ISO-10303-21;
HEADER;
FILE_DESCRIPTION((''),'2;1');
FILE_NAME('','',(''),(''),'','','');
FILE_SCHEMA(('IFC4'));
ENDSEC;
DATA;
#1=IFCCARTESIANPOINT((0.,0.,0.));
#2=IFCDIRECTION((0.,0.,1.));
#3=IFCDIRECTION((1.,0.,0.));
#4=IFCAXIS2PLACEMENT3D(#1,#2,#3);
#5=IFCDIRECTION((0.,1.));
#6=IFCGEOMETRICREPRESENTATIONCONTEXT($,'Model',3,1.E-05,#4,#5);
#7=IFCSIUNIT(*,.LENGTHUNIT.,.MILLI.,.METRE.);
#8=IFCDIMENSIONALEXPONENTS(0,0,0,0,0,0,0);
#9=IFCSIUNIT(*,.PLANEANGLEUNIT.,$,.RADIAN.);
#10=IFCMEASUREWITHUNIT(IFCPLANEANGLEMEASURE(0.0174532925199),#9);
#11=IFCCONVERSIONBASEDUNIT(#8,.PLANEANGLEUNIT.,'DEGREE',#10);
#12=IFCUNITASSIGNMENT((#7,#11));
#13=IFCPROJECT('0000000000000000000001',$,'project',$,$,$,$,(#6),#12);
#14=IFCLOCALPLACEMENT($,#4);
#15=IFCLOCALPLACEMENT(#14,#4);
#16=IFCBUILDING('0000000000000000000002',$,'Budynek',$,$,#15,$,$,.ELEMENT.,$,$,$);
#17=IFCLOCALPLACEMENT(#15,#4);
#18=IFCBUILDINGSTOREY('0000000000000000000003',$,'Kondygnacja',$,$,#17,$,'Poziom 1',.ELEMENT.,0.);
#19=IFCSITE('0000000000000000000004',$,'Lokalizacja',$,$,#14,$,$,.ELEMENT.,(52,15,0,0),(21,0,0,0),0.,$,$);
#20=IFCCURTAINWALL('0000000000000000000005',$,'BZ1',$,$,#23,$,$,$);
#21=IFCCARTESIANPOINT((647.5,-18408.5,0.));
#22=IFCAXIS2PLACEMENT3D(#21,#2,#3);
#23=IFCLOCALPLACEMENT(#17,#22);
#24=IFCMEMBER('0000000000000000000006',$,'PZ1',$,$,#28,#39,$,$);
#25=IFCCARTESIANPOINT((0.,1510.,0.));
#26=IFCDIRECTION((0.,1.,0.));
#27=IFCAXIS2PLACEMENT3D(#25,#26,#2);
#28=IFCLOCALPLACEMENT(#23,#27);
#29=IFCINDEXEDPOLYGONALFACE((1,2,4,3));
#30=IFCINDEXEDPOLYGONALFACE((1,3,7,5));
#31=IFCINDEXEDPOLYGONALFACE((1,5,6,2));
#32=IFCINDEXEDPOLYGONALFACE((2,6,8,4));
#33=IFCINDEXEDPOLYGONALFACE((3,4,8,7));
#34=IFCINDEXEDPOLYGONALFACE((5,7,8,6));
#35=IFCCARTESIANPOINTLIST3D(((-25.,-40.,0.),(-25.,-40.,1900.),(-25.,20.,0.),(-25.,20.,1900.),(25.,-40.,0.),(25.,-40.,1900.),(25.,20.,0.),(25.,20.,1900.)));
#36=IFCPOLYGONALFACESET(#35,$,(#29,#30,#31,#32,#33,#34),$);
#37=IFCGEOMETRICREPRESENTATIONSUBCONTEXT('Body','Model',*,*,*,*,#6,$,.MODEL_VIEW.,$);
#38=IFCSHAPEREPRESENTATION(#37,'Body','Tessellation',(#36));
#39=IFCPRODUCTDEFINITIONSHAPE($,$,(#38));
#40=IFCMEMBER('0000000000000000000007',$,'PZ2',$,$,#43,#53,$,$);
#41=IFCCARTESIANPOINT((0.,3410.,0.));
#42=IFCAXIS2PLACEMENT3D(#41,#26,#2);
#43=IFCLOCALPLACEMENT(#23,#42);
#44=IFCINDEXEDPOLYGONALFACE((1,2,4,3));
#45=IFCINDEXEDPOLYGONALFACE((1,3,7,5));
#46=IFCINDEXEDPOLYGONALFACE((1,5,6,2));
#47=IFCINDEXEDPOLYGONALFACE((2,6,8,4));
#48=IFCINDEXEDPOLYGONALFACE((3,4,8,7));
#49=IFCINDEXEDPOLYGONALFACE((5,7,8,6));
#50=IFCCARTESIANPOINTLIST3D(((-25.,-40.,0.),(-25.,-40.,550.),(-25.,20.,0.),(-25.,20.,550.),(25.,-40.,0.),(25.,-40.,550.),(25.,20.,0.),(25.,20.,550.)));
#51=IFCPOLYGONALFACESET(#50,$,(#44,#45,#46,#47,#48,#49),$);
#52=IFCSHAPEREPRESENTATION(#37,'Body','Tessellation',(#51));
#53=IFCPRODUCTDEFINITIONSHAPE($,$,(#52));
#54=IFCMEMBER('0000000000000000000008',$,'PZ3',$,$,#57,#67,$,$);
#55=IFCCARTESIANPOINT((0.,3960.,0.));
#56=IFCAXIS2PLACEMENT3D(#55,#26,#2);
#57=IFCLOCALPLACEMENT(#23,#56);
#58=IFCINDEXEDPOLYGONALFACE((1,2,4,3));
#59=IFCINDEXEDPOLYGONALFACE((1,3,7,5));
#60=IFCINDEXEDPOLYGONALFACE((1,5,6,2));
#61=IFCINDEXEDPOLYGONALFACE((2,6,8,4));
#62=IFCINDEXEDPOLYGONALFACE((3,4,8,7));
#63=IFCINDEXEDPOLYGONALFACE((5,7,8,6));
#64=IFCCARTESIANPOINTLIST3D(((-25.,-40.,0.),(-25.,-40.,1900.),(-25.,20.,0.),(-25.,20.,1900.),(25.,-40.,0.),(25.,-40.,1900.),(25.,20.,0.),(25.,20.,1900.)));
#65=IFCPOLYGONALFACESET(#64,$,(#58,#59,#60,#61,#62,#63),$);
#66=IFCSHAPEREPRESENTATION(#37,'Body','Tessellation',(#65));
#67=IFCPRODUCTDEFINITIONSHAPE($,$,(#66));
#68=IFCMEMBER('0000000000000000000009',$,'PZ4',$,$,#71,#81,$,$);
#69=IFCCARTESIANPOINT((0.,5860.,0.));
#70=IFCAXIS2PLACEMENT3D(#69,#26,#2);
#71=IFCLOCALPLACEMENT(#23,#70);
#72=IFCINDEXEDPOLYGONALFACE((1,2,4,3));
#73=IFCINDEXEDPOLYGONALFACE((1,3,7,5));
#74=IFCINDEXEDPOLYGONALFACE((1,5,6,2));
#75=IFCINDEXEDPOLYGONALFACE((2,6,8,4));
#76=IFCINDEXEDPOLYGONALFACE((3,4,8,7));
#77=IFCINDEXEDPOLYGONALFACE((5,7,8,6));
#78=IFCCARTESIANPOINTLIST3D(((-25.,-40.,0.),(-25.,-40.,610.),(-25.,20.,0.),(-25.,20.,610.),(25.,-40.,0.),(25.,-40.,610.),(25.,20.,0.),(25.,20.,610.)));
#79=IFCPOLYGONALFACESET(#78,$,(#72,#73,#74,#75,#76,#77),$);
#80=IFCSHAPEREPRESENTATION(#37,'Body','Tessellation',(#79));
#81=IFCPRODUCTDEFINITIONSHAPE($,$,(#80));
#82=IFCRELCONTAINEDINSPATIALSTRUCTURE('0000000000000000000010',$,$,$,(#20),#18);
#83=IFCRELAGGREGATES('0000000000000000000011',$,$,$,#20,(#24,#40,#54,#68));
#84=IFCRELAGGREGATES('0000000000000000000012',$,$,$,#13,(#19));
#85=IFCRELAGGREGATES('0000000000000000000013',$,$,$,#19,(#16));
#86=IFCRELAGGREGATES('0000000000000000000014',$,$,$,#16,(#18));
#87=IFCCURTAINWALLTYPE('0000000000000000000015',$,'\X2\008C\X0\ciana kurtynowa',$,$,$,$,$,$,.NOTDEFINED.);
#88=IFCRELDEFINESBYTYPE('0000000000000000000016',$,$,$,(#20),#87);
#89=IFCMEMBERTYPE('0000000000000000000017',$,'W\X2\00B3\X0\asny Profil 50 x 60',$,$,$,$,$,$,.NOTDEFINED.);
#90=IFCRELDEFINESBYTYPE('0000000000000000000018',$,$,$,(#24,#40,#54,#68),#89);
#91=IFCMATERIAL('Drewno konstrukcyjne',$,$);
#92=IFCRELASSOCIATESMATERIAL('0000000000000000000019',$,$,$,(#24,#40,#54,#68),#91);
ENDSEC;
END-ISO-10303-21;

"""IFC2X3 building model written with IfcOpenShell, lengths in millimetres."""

from ifc_helpers import new_model, entity, si_unit, converted_unit, direction, frame, origin_with_axes, place, context, subcontext, project, spatial, polyline, outline, extrude, material, type_object, element, aggregate, save


model = new_model("IFC2X3")

# Units and contexts
model_context = context("Model", 3, precision=1e-05, world=origin_with_axes(), true_north=direction((0.0, 1.0)))
body_context = subcontext(model_context, "Body", "Model", "MODEL_VIEW")
ifc_project = project(units=[si_unit("LENGTHUNIT", "METRE", prefix="MILLI"), converted_unit("PLANEANGLEUNIT", "DEGREE", entity("IfcPlaneAngleMeasure", 0.0174532925199), si_unit("PLANEANGLEUNIT", "RADIAN"), dimensions=[0, 0, 0, 0, 0, 0, 0])], contexts=[model_context])

# Site, building, storey
site_placement = place(None, origin_with_axes())
site = spatial("IfcSite", under=ifc_project, at=site_placement, Name="Lokalizacja", CompositionType="ELEMENT", RefLatitude=(52, 15, 0, 0), RefLongitude=(21, 0, 0, 0), RefElevation=0.0)
building_placement = place(site_placement, origin_with_axes())
building = spatial("IfcBuilding", under=site, at=building_placement, Name="Budynek", CompositionType="ELEMENT")
storey_placement = place(building_placement, origin_with_axes())
storey = spatial("IfcBuildingStorey", under=building, at=storey_placement, Name="Kondygnacja", LongName="Poziom 1", CompositionType="ELEMENT", Elevation=0.0)

# Curtain wall, members
curtain_wall_type = type_object("IfcCurtainWallType", Name="\u008cciana kurtynowa", PredefinedType="NOTDEFINED")
curtain_wall_placement = place(storey_placement, frame((647.5, -18408.5, 0.0), z_axis=(0.0, 0.0, 1.0), x_axis=(1.0, 0.0, 0.0)))
curtain_wall = element("IfcCurtainWall", 1, at=curtain_wall_placement, inside=storey, type_object=curtain_wall_type, Name="BZ1")
ifc_material_1 = material(Name="Drewno konstrukcyjne")
member_type_1 = type_object("IfcMemberType", Name="W³asny Profil 50 x 60", PredefinedType="NOTDEFINED")
member_1_placement = place(curtain_wall_placement, frame((0.0, 1510.0, 0.0), z_axis=(0.0, 1.0, 0.0), x_axis=(0.0, 0.0, 1.0)))
member_1 = element("IfcMember", 2, at=member_1_placement, type_object=member_type_1, material=ifc_material_1, Name="PZ1", context=body_context, shape_type="SweptSolid", body=[
    extrude(outline(polyline([(-40.0, -25.0), (20.0, -25.0), (20.0, 25.0), (-40.0, 25.0), (-40.0, -25.0)])), frame((0.0, 0.0, 0.0), z_axis=(0.0, 0.0, 1.0), x_axis=(0.0, 1.0, 0.0)), (0.0, 0.0, 1.0), 1900.0),
])
member_2_placement = place(curtain_wall_placement, frame((0.0, 3410.0, 0.0), z_axis=(0.0, 1.0, 0.0), x_axis=(0.0, 0.0, 1.0)))
member_2 = element("IfcMember", 3, at=member_2_placement, type_object=member_type_1, material=ifc_material_1, Name="PZ2", context=body_context, shape_type="SweptSolid", body=[
    extrude(outline(polyline([(-40.0, -25.0), (20.0, -25.0), (20.0, 25.0), (-40.0, 25.0), (-40.0, -25.0)])), frame((0.0, 0.0, 0.0), z_axis=(0.0, 0.0, 1.0), x_axis=(0.0, 1.0, 0.0)), (0.0, 0.0, 1.0), 550.0),
])
member_3_placement = place(curtain_wall_placement, frame((0.0, 3960.0, 0.0), z_axis=(0.0, 1.0, 0.0), x_axis=(0.0, 0.0, 1.0)))
member_3 = element("IfcMember", 4, at=member_3_placement, type_object=member_type_1, material=ifc_material_1, Name="PZ3", context=body_context, shape_type="SweptSolid", body=[
    extrude(outline(polyline([(-40.0, -25.0), (20.0, -25.0), (20.0, 25.0), (-40.0, 25.0), (-40.0, -25.0)])), frame((0.0, 0.0, 0.0), z_axis=(0.0, 0.0, 1.0), x_axis=(0.0, 1.0, 0.0)), (0.0, 0.0, 1.0), 1900.0),
])
member_4_placement = place(curtain_wall_placement, frame((0.0, 5860.0, 0.0), z_axis=(0.0, 1.0, 0.0), x_axis=(0.0, 0.0, 1.0)))
member_4 = element("IfcMember", 5, at=member_4_placement, type_object=member_type_1, material=ifc_material_1, Name="PZ4", context=body_context, shape_type="SweptSolid", body=[
    extrude(outline(polyline([(-40.0, -25.0), (20.0, -25.0), (20.0, 25.0), (-40.0, 25.0), (-40.0, -25.0)])), frame((0.0, 0.0, 0.0), z_axis=(0.0, 0.0, 1.0), x_axis=(0.0, 1.0, 0.0)), (0.0, 0.0, 1.0), 610.0),
])
aggregate(curtain_wall, [member_1, member_2, member_3, member_4])

save(model, "model.ifc")
